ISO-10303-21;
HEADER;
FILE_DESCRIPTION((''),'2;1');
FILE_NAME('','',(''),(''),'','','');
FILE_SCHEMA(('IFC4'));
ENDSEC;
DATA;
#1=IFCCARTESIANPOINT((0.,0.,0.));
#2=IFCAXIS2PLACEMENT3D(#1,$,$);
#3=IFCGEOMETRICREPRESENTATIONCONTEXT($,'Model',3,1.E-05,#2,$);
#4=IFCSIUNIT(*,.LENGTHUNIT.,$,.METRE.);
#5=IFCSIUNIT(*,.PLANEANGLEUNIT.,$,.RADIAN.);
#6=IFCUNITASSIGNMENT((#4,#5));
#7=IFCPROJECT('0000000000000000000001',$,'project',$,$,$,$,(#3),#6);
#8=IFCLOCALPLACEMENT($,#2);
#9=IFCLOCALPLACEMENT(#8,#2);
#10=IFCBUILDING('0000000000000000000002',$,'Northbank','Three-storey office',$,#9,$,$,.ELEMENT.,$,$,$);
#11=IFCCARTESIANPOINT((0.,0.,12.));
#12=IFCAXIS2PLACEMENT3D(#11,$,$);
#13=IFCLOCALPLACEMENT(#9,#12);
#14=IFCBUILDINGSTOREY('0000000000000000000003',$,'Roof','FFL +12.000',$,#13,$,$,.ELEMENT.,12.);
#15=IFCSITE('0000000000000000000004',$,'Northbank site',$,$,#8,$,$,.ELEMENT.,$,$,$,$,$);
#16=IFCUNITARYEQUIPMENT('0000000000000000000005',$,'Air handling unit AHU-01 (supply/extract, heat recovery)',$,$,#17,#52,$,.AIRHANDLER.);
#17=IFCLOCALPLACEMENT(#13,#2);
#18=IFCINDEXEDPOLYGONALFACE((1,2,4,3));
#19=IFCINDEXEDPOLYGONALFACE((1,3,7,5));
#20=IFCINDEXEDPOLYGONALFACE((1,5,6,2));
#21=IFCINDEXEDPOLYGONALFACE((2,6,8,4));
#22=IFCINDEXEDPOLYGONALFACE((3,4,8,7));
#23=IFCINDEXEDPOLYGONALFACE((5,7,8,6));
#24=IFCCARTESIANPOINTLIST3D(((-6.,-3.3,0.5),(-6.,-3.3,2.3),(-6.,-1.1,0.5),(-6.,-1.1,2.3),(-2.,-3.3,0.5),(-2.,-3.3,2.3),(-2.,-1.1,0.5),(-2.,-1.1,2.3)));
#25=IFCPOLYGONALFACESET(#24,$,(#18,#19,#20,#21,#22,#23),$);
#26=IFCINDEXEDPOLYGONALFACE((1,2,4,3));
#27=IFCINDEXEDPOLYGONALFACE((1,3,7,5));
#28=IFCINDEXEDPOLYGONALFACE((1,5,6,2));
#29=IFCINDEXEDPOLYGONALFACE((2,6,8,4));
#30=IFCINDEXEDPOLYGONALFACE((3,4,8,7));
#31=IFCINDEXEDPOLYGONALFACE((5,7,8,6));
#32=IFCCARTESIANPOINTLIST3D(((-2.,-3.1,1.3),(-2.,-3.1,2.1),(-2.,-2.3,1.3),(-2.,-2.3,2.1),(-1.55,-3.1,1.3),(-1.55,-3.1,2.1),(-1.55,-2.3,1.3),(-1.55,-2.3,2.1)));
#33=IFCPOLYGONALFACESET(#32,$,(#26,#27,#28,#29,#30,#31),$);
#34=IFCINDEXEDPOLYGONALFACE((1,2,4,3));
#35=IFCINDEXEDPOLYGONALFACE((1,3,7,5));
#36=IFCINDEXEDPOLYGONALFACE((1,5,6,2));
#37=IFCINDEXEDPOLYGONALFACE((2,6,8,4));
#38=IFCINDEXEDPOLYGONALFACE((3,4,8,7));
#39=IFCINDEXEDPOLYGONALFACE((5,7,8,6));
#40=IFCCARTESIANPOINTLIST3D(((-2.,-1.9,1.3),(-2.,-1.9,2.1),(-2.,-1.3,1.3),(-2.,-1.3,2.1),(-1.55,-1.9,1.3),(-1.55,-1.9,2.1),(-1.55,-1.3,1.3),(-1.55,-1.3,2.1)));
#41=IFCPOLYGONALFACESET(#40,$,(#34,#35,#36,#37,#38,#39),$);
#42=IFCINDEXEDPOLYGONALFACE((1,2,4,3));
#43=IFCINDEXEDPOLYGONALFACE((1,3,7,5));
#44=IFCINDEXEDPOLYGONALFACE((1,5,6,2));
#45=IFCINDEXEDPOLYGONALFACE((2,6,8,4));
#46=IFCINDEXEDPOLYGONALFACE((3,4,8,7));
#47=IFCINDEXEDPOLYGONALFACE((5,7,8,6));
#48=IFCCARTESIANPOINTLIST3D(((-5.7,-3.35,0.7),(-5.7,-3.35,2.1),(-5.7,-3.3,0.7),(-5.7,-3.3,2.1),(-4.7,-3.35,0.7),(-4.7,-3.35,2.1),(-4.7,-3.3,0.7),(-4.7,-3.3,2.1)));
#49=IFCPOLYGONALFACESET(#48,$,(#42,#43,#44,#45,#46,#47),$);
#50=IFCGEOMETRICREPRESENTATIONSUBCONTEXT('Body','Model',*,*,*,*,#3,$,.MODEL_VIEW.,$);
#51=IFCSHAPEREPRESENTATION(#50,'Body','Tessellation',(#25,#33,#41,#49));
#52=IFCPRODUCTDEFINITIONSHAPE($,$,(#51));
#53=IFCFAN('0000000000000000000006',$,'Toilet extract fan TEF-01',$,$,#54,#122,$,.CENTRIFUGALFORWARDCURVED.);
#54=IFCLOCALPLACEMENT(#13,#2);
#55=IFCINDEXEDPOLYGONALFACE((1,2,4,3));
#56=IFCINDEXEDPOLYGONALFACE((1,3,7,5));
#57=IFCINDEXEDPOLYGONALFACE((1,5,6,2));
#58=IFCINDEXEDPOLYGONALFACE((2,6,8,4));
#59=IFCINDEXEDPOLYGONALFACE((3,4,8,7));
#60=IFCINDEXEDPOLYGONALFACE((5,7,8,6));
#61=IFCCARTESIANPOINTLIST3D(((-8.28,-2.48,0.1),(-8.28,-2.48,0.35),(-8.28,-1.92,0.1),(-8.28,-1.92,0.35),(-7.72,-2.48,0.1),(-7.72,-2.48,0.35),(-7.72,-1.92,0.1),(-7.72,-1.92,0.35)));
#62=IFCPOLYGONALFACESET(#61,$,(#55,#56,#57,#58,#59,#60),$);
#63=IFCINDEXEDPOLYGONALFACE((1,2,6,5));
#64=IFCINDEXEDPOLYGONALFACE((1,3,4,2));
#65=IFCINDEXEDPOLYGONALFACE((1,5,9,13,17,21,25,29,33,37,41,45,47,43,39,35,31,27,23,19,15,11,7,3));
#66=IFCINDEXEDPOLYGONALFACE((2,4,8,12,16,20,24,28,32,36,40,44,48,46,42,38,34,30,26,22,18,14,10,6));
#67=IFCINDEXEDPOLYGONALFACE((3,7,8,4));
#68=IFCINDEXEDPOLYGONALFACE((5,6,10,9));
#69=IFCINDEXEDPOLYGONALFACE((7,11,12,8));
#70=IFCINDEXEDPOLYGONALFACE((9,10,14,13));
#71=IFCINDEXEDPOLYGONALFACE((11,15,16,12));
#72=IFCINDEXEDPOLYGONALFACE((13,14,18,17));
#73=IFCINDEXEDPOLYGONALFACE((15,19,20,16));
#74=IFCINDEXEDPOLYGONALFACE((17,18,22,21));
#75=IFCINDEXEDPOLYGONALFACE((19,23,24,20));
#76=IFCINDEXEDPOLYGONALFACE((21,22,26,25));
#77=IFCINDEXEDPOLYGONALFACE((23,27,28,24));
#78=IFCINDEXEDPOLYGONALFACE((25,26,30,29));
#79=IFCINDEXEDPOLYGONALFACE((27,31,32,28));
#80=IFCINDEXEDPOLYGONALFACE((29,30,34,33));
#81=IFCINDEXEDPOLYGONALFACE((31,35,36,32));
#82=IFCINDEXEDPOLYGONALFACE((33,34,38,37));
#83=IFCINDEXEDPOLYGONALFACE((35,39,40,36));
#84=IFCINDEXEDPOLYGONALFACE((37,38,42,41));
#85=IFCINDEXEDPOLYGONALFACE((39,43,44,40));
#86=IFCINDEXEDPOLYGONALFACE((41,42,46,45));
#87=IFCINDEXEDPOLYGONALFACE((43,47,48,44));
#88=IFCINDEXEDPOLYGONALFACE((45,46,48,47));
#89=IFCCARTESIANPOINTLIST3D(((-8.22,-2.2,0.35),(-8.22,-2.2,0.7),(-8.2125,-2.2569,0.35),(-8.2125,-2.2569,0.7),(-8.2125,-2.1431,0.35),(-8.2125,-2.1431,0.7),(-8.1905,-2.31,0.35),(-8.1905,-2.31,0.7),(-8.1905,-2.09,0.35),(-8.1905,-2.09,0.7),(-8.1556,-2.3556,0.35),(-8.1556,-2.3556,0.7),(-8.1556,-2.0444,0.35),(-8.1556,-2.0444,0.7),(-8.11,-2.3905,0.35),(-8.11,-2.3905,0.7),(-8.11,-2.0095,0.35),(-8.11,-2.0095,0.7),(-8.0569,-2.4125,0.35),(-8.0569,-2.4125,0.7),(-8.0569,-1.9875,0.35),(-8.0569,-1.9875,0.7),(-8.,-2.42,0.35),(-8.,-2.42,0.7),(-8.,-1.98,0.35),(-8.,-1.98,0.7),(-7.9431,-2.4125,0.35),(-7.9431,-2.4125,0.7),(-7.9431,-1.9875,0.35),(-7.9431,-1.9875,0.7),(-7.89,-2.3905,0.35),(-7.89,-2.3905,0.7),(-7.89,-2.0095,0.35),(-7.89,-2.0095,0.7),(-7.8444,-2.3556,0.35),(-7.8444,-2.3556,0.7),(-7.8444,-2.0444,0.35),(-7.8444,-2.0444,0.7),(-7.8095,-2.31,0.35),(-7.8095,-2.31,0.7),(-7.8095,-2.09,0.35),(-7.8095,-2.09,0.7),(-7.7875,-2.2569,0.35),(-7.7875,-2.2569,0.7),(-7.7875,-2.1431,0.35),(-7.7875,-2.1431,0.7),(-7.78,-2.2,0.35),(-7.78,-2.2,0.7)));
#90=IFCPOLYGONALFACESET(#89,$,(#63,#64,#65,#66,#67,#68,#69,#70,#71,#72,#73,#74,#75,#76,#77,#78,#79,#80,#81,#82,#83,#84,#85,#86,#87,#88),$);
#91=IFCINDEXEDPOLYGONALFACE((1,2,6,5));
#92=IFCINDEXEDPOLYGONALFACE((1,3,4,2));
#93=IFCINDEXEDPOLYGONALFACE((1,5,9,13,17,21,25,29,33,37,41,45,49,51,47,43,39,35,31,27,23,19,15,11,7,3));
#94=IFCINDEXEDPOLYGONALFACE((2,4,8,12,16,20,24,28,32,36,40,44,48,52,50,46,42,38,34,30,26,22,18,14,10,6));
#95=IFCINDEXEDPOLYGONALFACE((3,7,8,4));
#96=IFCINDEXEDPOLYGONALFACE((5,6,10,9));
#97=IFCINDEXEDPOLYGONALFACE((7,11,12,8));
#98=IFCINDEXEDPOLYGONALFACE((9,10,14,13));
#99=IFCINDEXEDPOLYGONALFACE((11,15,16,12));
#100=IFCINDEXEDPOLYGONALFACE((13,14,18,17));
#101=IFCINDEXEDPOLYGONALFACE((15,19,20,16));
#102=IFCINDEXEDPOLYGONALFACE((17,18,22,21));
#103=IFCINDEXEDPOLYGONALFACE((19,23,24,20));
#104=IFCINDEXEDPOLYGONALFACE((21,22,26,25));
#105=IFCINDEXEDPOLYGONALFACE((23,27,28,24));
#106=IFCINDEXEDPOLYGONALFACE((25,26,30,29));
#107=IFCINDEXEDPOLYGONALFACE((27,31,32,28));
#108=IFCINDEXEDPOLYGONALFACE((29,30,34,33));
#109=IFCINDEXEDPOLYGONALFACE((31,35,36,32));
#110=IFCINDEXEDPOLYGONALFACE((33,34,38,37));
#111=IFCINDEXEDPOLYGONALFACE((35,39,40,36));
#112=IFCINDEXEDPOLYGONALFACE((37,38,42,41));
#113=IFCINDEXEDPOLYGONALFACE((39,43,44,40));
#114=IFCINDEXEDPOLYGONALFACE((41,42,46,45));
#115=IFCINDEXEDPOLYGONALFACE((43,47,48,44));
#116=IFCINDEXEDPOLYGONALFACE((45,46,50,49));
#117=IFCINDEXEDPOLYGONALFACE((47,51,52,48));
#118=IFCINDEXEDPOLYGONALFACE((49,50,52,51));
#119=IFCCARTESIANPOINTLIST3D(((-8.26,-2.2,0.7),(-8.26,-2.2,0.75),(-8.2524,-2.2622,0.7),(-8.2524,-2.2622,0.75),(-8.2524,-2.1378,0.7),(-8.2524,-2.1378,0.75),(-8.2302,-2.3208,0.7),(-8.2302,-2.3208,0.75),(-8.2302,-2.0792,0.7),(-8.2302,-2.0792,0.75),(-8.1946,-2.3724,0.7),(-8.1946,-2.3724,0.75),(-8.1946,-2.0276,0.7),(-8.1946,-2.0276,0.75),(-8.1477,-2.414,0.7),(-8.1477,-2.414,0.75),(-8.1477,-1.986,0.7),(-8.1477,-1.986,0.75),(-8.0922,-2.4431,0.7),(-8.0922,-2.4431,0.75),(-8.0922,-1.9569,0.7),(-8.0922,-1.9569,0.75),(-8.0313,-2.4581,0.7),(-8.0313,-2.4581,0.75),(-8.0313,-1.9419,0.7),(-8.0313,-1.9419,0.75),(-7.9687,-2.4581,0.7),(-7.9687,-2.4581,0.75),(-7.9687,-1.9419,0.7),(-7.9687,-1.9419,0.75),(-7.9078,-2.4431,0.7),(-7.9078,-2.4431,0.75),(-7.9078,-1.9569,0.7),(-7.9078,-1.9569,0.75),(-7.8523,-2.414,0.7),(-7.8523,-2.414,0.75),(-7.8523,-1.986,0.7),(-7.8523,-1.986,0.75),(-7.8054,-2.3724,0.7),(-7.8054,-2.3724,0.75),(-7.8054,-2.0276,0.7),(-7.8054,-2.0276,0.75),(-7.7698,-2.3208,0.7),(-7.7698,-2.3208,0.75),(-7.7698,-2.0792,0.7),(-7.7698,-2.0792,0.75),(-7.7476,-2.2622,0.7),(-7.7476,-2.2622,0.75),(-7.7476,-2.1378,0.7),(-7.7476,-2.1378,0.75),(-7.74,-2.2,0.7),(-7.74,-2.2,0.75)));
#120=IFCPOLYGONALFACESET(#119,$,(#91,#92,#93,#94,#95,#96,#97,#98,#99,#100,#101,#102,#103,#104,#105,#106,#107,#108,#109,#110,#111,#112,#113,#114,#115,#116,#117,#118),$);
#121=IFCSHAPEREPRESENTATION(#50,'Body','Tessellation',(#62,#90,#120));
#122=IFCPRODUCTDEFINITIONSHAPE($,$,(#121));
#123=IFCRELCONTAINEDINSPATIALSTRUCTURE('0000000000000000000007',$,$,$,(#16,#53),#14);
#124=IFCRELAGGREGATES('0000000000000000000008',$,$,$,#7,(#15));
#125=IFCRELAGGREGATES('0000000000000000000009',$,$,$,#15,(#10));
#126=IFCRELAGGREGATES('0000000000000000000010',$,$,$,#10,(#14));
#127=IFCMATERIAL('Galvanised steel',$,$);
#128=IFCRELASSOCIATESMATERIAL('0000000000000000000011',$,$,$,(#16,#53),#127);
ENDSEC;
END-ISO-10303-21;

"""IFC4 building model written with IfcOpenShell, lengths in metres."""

from ifc_helpers import new_model, si_unit, frame, origin, place, context, subcontext, project, spatial, rectangle, circle, extrude, material, element, save


model = new_model("IFC4")

# Units and contexts
model_context = context("Model", 3, precision=1e-05, world=origin())
body_context = subcontext(model_context, "Body", "Model", "MODEL_VIEW")
ifc_project = project(units=[si_unit("LENGTHUNIT", "METRE"), si_unit("PLANEANGLEUNIT", "RADIAN")], contexts=[model_context])

# Site, building, storey
site_placement = place(None, origin())
site = spatial("IfcSite", under=ifc_project, at=site_placement, Name="Northbank site", CompositionType="ELEMENT")
building_placement = place(site_placement, origin())
building = spatial("IfcBuilding", under=site, at=building_placement, Name="Northbank", Description="Three-storey office", CompositionType="ELEMENT")
storey_placement = place(building_placement, frame((0.0, 0.0, 12.0)))
storey = spatial("IfcBuildingStorey", under=building, at=storey_placement, Name="Roof", Description="FFL +12.000", CompositionType="ELEMENT", Elevation=12.0)

# Unitary equipment
ifc_material_1 = material(Name="Galvanised steel")
unitary_equipment_placement = place(storey_placement, frame((0.0, 0.0, -12.0)))
element("IfcUnitaryEquipment", 1, at=unitary_equipment_placement, inside=storey, material=ifc_material_1, Name="Air handling unit AHU-01 (supply/extract, heat recovery)", PredefinedType="AIRHANDLER", context=body_context, shape_type="SweptSolid", body=[
    extrude(rectangle(XDim=4.0, YDim=2.2), frame((-4.0, -2.2, 12.5)), (0.0, 0.0, 1.0), 1.8),
    extrude(rectangle(XDim=0.45, YDim=0.8), frame((-1.775, -2.7, 13.3)), (0.0, 0.0, 1.0), 0.8),
    extrude(rectangle(XDim=0.45, YDim=0.6), frame((-1.775, -1.6, 13.3)), (0.0, 0.0, 1.0), 0.8),
    extrude(rectangle(XDim=1.0, YDim=0.05), frame((-5.2, -3.325, 12.7)), (0.0, 0.0, 1.0), 1.4),
])

# Fan
fan_placement = place(storey_placement, frame((0.0, 0.0, -12.0)))
element("IfcFan", 2, at=fan_placement, inside=storey, material=ifc_material_1, Name="Toilet extract fan TEF-01", PredefinedType="CENTRIFUGALFORWARDCURVED", context=body_context, shape_type="SweptSolid", body=[
    extrude(rectangle(XDim=0.56, YDim=0.56), frame((-8.0, -2.2, 12.1)), (0.0, 0.0, 1.0), 0.25),
    extrude(circle(Radius=0.22), frame((-8.0, -2.2, 12.35), z_axis=(0.0, 0.0, 1.0), x_axis=(1.0, 0.0, 0.0)), (0.0, 0.0, 1.0), 0.35),
    extrude(circle(Radius=0.26), frame((-8.0, -2.2, 12.7), z_axis=(0.0, 0.0, 1.0), x_axis=(1.0, 0.0, 0.0)), (0.0, 0.0, 1.0), 0.05),
])

save(model, "model.ifc")
